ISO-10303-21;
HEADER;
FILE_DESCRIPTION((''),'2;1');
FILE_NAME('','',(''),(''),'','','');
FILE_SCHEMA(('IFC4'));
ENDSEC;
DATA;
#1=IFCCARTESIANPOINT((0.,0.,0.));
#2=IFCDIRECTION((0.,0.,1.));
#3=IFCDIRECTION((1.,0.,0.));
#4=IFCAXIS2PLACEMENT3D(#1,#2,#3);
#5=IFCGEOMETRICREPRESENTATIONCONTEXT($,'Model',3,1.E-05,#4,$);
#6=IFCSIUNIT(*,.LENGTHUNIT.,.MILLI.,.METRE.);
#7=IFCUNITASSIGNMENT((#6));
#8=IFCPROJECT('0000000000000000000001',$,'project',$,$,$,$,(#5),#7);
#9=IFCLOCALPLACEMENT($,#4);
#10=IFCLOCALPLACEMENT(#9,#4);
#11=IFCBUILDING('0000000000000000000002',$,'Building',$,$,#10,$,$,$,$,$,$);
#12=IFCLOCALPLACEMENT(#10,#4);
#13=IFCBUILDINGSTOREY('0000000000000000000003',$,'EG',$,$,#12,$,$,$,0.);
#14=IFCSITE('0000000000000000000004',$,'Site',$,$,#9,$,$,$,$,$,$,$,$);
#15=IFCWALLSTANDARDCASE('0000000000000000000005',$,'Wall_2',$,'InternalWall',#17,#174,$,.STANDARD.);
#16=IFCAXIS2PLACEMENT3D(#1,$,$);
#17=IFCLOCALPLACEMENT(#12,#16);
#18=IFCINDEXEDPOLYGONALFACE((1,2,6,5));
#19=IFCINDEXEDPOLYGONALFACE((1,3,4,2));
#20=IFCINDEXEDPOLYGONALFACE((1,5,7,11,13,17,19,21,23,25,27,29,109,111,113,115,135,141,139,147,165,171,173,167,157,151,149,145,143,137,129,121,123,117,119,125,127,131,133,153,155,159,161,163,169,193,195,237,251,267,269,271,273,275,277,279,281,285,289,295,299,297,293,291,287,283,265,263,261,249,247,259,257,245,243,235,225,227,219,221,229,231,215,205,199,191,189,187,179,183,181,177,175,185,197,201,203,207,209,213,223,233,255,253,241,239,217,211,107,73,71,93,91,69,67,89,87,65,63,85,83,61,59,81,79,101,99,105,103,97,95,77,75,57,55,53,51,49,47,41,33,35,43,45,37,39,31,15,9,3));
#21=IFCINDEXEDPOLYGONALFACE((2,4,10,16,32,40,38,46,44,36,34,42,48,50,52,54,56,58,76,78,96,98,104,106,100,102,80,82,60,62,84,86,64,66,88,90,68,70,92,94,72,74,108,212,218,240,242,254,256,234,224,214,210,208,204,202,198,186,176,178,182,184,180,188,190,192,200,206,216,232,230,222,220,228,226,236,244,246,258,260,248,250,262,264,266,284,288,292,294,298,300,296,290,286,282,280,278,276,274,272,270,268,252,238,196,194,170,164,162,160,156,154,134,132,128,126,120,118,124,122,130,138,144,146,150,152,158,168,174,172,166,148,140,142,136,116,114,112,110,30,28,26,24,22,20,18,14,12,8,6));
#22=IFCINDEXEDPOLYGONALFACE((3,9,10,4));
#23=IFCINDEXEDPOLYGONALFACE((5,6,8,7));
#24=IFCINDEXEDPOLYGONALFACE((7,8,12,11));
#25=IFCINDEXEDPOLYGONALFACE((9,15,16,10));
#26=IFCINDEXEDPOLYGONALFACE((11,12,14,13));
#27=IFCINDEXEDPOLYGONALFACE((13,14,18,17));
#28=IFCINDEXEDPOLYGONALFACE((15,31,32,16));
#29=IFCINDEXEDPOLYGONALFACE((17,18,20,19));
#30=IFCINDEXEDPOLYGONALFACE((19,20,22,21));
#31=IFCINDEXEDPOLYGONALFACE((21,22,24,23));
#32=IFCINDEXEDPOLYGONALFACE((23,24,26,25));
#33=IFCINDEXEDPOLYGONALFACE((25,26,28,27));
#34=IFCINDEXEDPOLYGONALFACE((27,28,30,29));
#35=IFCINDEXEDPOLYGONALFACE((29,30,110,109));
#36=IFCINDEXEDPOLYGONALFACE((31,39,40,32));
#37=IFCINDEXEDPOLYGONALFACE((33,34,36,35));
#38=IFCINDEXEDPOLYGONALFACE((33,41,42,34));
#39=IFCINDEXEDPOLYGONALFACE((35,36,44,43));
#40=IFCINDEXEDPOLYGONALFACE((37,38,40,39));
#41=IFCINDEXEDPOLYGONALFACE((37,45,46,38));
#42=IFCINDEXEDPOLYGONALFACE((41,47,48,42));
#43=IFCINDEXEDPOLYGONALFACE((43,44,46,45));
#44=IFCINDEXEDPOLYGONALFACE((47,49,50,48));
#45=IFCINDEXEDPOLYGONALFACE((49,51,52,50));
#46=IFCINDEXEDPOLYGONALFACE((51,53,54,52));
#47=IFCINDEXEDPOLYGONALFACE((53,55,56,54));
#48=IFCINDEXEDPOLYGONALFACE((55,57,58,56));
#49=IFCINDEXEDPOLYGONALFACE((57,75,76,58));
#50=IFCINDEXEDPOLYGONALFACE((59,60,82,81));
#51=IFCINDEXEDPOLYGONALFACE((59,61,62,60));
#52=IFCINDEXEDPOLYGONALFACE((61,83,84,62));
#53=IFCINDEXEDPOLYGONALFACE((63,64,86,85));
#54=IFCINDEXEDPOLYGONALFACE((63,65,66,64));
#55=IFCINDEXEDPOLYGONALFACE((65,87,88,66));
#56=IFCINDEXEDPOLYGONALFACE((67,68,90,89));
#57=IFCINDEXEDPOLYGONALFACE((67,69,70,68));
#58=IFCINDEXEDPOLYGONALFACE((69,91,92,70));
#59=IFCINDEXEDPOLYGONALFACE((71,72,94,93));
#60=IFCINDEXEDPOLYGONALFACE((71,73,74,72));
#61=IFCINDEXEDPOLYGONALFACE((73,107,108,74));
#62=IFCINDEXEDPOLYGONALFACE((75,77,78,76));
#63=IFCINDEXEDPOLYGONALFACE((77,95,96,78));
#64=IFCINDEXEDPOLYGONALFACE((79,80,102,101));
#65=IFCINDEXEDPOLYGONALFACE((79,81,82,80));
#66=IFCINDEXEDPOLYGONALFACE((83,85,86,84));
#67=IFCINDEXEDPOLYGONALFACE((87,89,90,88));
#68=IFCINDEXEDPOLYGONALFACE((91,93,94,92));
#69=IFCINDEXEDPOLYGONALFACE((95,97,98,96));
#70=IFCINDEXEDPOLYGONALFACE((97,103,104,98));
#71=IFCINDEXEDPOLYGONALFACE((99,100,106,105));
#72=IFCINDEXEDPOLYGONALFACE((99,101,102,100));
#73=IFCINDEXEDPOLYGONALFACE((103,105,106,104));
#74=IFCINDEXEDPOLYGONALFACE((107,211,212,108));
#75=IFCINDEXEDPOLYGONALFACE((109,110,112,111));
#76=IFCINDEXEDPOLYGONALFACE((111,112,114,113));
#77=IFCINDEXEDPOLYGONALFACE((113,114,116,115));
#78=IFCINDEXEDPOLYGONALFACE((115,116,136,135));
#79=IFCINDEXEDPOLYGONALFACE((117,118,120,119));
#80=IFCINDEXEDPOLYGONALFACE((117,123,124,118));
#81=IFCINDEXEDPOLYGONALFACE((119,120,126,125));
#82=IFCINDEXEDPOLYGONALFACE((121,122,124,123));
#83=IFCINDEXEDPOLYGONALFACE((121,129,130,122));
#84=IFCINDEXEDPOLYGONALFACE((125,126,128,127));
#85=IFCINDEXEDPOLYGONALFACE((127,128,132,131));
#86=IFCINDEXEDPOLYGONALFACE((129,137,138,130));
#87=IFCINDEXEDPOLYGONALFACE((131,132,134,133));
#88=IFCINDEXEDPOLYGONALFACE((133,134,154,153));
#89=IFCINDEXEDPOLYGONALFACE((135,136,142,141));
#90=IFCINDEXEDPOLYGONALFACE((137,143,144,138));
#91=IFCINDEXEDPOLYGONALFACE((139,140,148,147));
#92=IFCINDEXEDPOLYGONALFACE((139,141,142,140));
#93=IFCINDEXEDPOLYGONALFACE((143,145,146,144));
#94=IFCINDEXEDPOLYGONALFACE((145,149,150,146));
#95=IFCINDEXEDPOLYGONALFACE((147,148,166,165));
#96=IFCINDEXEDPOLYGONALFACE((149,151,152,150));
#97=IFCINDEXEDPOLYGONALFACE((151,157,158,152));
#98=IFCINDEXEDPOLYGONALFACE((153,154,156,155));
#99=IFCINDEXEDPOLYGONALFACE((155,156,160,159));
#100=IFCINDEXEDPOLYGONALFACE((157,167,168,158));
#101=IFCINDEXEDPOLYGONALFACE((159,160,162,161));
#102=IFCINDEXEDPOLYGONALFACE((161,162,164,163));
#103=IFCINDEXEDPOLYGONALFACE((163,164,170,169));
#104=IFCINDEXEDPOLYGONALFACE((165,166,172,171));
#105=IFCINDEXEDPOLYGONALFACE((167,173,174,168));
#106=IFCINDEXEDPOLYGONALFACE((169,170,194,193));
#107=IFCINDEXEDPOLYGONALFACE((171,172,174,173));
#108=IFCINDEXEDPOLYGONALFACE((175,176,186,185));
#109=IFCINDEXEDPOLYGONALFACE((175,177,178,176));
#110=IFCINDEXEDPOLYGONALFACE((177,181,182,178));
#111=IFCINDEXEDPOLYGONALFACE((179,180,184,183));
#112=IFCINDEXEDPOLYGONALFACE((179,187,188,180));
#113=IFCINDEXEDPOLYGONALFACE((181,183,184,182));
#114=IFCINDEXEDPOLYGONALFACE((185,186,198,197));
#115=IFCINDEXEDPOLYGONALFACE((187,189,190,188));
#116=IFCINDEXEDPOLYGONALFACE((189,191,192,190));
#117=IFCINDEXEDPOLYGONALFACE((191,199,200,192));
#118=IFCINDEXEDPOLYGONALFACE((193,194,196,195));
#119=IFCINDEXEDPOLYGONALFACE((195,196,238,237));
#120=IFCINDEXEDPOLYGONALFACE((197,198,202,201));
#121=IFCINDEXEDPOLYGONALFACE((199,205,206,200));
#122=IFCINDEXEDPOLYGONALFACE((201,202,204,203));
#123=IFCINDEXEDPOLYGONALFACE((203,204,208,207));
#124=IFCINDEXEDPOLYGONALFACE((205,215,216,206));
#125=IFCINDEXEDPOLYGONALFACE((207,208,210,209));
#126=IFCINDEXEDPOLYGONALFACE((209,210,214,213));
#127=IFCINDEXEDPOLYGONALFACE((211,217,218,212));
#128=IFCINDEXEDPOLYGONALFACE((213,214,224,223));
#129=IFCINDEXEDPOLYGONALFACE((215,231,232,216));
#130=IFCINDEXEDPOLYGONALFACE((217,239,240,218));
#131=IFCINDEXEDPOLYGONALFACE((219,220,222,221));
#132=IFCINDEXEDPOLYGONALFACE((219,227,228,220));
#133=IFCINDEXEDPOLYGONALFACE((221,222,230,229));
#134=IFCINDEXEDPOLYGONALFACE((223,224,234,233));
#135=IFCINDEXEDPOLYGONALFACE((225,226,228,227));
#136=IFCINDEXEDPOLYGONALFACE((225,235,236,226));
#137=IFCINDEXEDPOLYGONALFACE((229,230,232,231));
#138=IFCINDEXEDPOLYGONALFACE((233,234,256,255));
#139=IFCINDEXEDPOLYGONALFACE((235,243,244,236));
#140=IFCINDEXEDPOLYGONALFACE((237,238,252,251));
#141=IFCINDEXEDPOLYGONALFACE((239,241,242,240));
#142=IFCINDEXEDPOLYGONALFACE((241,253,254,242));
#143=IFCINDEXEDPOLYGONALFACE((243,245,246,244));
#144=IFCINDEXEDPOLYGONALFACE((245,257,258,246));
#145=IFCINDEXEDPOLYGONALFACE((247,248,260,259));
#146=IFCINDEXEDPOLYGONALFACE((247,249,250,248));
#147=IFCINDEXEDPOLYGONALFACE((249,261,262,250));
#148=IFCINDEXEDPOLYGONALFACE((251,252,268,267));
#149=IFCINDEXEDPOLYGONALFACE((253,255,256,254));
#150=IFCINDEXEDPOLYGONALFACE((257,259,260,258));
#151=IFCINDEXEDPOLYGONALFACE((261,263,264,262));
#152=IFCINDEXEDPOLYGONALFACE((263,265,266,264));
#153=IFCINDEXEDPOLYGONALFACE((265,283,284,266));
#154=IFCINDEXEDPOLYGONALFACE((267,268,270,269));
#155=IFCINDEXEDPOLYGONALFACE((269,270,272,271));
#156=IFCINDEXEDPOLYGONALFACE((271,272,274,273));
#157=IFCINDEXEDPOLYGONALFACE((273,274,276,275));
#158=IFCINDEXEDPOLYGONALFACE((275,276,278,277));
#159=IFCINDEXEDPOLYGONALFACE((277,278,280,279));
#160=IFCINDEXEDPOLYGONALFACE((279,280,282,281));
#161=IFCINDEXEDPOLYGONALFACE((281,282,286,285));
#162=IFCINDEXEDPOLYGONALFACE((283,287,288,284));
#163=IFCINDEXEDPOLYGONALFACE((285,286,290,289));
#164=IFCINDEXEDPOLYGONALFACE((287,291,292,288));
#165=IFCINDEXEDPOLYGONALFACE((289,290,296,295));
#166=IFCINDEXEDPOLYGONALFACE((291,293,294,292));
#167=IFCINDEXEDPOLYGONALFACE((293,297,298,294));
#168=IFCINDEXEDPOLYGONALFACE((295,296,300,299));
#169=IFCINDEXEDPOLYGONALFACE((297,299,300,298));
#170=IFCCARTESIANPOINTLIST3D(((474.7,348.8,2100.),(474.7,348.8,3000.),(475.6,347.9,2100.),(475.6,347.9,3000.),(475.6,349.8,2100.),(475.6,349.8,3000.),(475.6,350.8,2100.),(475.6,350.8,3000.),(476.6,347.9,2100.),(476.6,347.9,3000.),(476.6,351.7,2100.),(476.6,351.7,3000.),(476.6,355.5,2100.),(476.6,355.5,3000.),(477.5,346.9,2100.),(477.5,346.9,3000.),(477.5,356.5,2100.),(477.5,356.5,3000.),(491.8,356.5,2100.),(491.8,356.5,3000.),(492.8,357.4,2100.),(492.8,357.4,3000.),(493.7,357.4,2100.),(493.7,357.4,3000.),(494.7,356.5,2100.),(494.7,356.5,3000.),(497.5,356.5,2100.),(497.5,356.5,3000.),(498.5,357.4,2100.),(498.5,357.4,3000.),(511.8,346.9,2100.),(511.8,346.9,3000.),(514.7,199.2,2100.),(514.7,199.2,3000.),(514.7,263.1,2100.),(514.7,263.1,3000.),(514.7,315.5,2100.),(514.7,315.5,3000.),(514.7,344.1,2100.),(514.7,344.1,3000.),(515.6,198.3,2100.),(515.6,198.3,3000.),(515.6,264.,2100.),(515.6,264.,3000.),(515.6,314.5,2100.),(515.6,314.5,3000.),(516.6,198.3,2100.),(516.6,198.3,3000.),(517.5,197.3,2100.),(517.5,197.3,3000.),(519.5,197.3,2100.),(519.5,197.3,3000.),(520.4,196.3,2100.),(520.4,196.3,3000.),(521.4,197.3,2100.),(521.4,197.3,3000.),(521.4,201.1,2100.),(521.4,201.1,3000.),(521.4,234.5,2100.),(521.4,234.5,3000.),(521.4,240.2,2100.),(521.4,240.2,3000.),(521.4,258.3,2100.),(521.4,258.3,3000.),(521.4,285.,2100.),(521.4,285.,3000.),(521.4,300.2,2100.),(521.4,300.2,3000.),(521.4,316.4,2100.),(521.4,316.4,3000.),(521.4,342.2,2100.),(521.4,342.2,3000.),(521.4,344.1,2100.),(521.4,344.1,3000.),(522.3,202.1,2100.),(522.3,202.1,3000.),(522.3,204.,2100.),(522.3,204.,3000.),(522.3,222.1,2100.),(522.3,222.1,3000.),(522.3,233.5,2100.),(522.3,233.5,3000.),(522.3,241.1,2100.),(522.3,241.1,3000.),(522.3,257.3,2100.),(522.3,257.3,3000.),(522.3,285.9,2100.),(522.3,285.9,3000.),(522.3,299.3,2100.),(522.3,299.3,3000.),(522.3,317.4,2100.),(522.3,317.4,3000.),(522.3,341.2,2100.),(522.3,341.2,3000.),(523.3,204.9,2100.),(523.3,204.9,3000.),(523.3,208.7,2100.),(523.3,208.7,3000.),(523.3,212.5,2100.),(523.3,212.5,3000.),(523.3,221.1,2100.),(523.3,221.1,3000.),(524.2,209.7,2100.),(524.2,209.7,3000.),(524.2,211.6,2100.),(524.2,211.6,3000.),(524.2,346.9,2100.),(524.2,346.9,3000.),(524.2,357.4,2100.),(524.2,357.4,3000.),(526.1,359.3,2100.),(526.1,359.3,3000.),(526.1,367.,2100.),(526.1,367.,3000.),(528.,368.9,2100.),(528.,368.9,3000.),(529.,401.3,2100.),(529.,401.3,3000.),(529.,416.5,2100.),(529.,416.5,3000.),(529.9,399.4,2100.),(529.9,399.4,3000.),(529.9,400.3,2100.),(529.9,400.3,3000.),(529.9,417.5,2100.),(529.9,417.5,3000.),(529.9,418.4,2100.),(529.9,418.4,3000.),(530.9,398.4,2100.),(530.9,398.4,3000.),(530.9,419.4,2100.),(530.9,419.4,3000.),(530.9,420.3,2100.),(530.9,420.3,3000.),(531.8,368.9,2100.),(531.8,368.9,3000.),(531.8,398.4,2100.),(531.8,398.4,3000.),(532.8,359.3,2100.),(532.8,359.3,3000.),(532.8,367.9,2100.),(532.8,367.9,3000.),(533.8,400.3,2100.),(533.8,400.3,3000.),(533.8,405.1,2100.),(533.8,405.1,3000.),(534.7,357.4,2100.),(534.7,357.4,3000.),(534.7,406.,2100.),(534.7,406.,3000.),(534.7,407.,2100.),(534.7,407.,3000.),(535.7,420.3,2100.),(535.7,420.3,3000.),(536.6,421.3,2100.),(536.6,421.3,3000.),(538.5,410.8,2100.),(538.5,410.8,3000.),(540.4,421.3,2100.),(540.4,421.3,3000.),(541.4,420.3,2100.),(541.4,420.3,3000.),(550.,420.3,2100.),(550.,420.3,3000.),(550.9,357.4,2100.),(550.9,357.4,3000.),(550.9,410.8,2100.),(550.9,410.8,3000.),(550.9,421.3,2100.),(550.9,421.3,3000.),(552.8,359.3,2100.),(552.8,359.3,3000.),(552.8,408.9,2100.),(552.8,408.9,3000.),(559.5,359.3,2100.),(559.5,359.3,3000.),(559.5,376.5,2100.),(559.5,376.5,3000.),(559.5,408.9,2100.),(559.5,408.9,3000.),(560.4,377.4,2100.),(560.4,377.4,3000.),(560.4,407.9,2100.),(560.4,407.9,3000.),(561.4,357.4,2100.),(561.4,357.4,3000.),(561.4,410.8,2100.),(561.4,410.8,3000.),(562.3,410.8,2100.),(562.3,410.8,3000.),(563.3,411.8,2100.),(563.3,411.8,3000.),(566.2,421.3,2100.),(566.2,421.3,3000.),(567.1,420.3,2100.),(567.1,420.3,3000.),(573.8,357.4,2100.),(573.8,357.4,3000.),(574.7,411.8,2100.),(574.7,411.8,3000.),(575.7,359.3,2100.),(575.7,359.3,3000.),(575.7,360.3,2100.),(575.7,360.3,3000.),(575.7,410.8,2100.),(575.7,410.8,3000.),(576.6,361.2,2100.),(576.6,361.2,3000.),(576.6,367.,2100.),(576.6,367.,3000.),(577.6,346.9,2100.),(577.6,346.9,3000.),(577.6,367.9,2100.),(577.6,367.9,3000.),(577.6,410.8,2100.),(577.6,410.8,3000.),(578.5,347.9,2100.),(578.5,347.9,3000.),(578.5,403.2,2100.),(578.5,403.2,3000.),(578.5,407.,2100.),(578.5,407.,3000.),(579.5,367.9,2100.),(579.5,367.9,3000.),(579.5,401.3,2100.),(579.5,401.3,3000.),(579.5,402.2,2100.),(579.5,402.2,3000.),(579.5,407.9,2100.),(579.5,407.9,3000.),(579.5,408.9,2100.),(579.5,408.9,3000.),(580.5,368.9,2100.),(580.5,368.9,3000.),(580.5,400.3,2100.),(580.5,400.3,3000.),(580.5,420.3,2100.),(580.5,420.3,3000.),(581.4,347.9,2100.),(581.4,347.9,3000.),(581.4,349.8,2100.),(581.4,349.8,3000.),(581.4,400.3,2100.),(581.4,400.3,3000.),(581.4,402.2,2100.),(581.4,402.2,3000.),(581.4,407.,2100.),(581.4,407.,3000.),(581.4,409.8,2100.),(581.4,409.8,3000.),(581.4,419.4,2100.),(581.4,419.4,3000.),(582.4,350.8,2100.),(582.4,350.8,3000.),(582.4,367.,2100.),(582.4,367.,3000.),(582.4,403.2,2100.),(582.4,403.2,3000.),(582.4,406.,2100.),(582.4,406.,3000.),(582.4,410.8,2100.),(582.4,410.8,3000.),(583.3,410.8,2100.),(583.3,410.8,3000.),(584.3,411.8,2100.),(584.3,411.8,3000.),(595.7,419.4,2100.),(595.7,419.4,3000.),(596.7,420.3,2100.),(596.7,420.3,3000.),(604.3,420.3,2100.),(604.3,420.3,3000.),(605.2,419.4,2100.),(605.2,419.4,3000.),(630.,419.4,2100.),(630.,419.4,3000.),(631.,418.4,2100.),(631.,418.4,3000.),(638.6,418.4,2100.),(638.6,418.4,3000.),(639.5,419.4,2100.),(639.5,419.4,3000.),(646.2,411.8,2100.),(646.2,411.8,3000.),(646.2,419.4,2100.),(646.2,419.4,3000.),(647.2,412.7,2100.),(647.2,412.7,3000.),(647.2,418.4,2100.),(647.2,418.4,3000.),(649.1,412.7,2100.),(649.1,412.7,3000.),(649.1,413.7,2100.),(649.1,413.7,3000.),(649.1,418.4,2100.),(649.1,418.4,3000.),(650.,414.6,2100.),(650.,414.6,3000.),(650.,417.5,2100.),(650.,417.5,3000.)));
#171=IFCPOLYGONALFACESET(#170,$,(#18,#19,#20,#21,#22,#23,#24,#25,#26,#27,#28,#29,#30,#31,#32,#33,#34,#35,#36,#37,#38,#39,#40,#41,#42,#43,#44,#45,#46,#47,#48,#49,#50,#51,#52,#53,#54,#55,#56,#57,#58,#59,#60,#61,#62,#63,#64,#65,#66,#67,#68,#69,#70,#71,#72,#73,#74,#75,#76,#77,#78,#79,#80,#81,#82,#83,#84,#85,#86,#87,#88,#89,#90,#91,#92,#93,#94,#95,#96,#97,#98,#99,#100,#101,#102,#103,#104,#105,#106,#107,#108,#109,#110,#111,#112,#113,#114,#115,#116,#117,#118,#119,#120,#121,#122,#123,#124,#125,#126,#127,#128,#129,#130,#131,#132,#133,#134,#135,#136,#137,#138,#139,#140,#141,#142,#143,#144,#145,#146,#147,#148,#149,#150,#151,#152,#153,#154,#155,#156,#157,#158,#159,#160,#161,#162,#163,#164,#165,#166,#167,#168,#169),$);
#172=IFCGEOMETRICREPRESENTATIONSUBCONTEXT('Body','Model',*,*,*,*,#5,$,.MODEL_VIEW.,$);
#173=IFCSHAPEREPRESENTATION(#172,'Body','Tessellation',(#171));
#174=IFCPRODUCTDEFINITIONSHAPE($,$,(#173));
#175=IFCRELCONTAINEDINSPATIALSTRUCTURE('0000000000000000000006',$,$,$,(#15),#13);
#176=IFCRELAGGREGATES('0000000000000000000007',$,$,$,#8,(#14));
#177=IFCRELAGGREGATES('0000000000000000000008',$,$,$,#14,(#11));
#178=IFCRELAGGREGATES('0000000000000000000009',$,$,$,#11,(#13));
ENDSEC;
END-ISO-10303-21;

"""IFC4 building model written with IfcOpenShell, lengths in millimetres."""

from ifc_helpers import new_model, si_unit, frame, origin_with_axes, place, context, subcontext, project, spatial, polyline, rectangle, outline, extrude, element, save


model = new_model("IFC4")

# Units and contexts
model_context = context("Model", 3, precision=1e-05, world=origin_with_axes())
body_context = subcontext(model_context, "Body", "Model", "MODEL_VIEW")
ifc_project = project(units=[si_unit("LENGTHUNIT", "METRE", prefix="MILLI")], contexts=[model_context])

# Site, building, storey
site_placement = place(None, origin_with_axes())
site = spatial("IfcSite", under=ifc_project, at=site_placement, Name="Site")
building_placement = place(site_placement, origin_with_axes())
building = spatial("IfcBuilding", under=site, at=building_placement, Name="Building")
storey_placement = place(building_placement, origin_with_axes())
storey = spatial("IfcBuildingStorey", under=building, at=storey_placement, Name="EG", Elevation=0.0)

# Wall, openings
wall_1_placement = place(storey_placement, origin_with_axes())
wall_1 = element("IfcWallStandardCase", 1, at=wall_1_placement, inside=storey, Name="Wall_2", ObjectType="InternalWall", PredefinedType="STANDARD", context=body_context, shape_type="SweptSolid", body=[
    extrude(outline(polyline([(520.4, 196.3, 0.0), (519.5, 197.3, 0.0), (517.5, 197.3, 0.0), (516.6, 198.3, 0.0), (515.6, 198.3, 0.0), (514.7, 199.2, 0.0), (514.7, 263.1, 0.0), (515.6, 264.0, 0.0), (515.6, 314.5, 0.0), (514.7, 315.5, 0.0), (514.7, 344.1, 0.0), (511.8, 346.9, 0.0), (477.5, 346.9, 0.0), (476.6, 347.9, 0.0), (475.6, 347.9, 0.0), (474.7, 348.8, 0.0), (475.6, 349.8, 0.0), (475.6, 350.8, 0.0), (476.6, 351.7, 0.0), (476.6, 355.5, 0.0), (477.5, 356.5, 0.0), (491.8, 356.5, 0.0), (492.8, 357.4, 0.0), (493.7, 357.4, 0.0), (494.7, 356.5, 0.0), (497.5, 356.5, 0.0), (498.5, 357.4, 0.0), (524.2, 357.4, 0.0), (526.1, 359.3, 0.0), (526.1, 367.0, 0.0), (528.0, 368.9, 0.0), (531.8, 368.9, 0.0), (532.8, 367.9, 0.0), (532.8, 359.3, 0.0), (534.7, 357.4, 0.0), (550.9, 357.4, 0.0), (552.8, 359.3, 0.0), (552.8, 408.9, 0.0), (550.9, 410.8, 0.0), (538.5, 410.8, 0.0), (534.7, 407.0, 0.0), (534.7, 406.0, 0.0), (533.8, 405.1, 0.0), (533.8, 400.3, 0.0), (531.8, 398.4, 0.0), (530.9, 398.4, 0.0), (529.9, 399.4, 0.0), (529.9, 400.3, 0.0), (529.0, 401.3, 0.0), (529.0, 416.5, 0.0), (529.9, 417.5, 0.0), (529.9, 418.4, 0.0), (530.9, 419.4, 0.0), (530.9, 420.3, 0.0), (535.7, 420.3, 0.0), (536.6, 421.3, 0.0), (540.4, 421.3, 0.0), (541.4, 420.3, 0.0), (550.0, 420.3, 0.0), (550.9, 421.3, 0.0), (566.2, 421.3, 0.0), (567.1, 420.3, 0.0), (580.5, 420.3, 0.0), (581.4, 419.4, 0.0), (595.7, 419.4, 0.0), (596.7, 420.3, 0.0), (604.3, 420.3, 0.0), (605.2, 419.4, 0.0), (630.0, 419.4, 0.0), (631.0, 418.4, 0.0), (638.6, 418.4, 0.0), (639.5, 419.4, 0.0), (646.2, 419.4, 0.0), (647.2, 418.4, 0.0), (649.1, 418.4, 0.0), (650.0, 417.5, 0.0), (650.0, 414.6, 0.0), (649.1, 413.7, 0.0), (649.1, 412.7, 0.0), (647.2, 412.7, 0.0), (646.2, 411.8, 0.0), (584.3, 411.8, 0.0), (583.3, 410.8, 0.0), (582.4, 410.8, 0.0), (581.4, 409.8, 0.0), (581.4, 407.0, 0.0), (582.4, 406.0, 0.0), (582.4, 403.2, 0.0), (581.4, 402.2, 0.0), (581.4, 400.3, 0.0), (580.5, 400.3, 0.0), (579.5, 401.3, 0.0), (579.5, 402.2, 0.0), (578.5, 403.2, 0.0), (578.5, 407.0, 0.0), (579.5, 407.9, 0.0), (579.5, 408.9, 0.0), (577.6, 410.8, 0.0), (575.7, 410.8, 0.0), (574.7, 411.8, 0.0), (563.3, 411.8, 0.0), (562.3, 410.8, 0.0), (561.4, 410.8, 0.0), (559.5, 408.9, 0.0), (560.4, 407.9, 0.0), (560.4, 377.4, 0.0), (559.5, 376.5, 0.0), (559.5, 359.3, 0.0), (561.4, 357.4, 0.0), (573.8, 357.4, 0.0), (575.7, 359.3, 0.0), (575.7, 360.3, 0.0), (576.6, 361.2, 0.0), (576.6, 367.0, 0.0), (577.6, 367.9, 0.0), (579.5, 367.9, 0.0), (580.5, 368.9, 0.0), (582.4, 367.0, 0.0), (582.4, 350.8, 0.0), (581.4, 349.8, 0.0), (581.4, 347.9, 0.0), (578.5, 347.9, 0.0), (577.6, 346.9, 0.0), (524.2, 346.9, 0.0), (521.4, 344.1, 0.0), (521.4, 342.2, 0.0), (522.3, 341.2, 0.0), (522.3, 317.4, 0.0), (521.4, 316.4, 0.0), (521.4, 300.2, 0.0), (522.3, 299.3, 0.0), (522.3, 285.9, 0.0), (521.4, 285.0, 0.0), (521.4, 258.3, 0.0), (522.3, 257.3, 0.0), (522.3, 241.1, 0.0), (521.4, 240.2, 0.0), (521.4, 234.5, 0.0), (522.3, 233.5, 0.0), (522.3, 222.1, 0.0), (523.3, 221.1, 0.0), (523.3, 212.5, 0.0), (524.2, 211.6, 0.0), (524.2, 209.7, 0.0), (523.3, 208.7, 0.0), (523.3, 204.9, 0.0), (522.3, 204.0, 0.0), (522.3, 202.1, 0.0), (521.4, 201.1, 0.0), (521.4, 197.3, 0.0), (520.4, 196.3, 0.0)])), origin_with_axes(), (0.0, 0.0, 1.0), 3000.0),
])
opening_1_placement = place(wall_1_placement, origin_with_axes())
element("IfcOpeningElement", 2, at=opening_1_placement, inside=storey, cuts=wall_1, context=body_context, shape_type="SweptSolid", body=[
    extrude(rectangle(XDim=450.0, YDim=119.2), frame((549.1, 360.9, 0.0), z_axis=(0.0, 0.0, 1.0), x_axis=(0.510011, 0.860168, 0.0)), (0.0, 0.0, 1.0), 2100.0),
])
opening_2_placement = place(wall_1_placement, origin_with_axes())
element("IfcOpeningElement", 3, at=opening_2_placement, inside=storey, cuts=wall_1, context=body_context, shape_type="SweptSolid", body=[
    extrude(rectangle(XDim=450.0, YDim=119.2), frame((568.7, 394.1, 0.0), z_axis=(0.0, 0.0, 1.0), x_axis=(0.510011, 0.860168, 0.0)), (0.0, 0.0, 1.0), 2100.0),
])

save(model, "model.ifc")
